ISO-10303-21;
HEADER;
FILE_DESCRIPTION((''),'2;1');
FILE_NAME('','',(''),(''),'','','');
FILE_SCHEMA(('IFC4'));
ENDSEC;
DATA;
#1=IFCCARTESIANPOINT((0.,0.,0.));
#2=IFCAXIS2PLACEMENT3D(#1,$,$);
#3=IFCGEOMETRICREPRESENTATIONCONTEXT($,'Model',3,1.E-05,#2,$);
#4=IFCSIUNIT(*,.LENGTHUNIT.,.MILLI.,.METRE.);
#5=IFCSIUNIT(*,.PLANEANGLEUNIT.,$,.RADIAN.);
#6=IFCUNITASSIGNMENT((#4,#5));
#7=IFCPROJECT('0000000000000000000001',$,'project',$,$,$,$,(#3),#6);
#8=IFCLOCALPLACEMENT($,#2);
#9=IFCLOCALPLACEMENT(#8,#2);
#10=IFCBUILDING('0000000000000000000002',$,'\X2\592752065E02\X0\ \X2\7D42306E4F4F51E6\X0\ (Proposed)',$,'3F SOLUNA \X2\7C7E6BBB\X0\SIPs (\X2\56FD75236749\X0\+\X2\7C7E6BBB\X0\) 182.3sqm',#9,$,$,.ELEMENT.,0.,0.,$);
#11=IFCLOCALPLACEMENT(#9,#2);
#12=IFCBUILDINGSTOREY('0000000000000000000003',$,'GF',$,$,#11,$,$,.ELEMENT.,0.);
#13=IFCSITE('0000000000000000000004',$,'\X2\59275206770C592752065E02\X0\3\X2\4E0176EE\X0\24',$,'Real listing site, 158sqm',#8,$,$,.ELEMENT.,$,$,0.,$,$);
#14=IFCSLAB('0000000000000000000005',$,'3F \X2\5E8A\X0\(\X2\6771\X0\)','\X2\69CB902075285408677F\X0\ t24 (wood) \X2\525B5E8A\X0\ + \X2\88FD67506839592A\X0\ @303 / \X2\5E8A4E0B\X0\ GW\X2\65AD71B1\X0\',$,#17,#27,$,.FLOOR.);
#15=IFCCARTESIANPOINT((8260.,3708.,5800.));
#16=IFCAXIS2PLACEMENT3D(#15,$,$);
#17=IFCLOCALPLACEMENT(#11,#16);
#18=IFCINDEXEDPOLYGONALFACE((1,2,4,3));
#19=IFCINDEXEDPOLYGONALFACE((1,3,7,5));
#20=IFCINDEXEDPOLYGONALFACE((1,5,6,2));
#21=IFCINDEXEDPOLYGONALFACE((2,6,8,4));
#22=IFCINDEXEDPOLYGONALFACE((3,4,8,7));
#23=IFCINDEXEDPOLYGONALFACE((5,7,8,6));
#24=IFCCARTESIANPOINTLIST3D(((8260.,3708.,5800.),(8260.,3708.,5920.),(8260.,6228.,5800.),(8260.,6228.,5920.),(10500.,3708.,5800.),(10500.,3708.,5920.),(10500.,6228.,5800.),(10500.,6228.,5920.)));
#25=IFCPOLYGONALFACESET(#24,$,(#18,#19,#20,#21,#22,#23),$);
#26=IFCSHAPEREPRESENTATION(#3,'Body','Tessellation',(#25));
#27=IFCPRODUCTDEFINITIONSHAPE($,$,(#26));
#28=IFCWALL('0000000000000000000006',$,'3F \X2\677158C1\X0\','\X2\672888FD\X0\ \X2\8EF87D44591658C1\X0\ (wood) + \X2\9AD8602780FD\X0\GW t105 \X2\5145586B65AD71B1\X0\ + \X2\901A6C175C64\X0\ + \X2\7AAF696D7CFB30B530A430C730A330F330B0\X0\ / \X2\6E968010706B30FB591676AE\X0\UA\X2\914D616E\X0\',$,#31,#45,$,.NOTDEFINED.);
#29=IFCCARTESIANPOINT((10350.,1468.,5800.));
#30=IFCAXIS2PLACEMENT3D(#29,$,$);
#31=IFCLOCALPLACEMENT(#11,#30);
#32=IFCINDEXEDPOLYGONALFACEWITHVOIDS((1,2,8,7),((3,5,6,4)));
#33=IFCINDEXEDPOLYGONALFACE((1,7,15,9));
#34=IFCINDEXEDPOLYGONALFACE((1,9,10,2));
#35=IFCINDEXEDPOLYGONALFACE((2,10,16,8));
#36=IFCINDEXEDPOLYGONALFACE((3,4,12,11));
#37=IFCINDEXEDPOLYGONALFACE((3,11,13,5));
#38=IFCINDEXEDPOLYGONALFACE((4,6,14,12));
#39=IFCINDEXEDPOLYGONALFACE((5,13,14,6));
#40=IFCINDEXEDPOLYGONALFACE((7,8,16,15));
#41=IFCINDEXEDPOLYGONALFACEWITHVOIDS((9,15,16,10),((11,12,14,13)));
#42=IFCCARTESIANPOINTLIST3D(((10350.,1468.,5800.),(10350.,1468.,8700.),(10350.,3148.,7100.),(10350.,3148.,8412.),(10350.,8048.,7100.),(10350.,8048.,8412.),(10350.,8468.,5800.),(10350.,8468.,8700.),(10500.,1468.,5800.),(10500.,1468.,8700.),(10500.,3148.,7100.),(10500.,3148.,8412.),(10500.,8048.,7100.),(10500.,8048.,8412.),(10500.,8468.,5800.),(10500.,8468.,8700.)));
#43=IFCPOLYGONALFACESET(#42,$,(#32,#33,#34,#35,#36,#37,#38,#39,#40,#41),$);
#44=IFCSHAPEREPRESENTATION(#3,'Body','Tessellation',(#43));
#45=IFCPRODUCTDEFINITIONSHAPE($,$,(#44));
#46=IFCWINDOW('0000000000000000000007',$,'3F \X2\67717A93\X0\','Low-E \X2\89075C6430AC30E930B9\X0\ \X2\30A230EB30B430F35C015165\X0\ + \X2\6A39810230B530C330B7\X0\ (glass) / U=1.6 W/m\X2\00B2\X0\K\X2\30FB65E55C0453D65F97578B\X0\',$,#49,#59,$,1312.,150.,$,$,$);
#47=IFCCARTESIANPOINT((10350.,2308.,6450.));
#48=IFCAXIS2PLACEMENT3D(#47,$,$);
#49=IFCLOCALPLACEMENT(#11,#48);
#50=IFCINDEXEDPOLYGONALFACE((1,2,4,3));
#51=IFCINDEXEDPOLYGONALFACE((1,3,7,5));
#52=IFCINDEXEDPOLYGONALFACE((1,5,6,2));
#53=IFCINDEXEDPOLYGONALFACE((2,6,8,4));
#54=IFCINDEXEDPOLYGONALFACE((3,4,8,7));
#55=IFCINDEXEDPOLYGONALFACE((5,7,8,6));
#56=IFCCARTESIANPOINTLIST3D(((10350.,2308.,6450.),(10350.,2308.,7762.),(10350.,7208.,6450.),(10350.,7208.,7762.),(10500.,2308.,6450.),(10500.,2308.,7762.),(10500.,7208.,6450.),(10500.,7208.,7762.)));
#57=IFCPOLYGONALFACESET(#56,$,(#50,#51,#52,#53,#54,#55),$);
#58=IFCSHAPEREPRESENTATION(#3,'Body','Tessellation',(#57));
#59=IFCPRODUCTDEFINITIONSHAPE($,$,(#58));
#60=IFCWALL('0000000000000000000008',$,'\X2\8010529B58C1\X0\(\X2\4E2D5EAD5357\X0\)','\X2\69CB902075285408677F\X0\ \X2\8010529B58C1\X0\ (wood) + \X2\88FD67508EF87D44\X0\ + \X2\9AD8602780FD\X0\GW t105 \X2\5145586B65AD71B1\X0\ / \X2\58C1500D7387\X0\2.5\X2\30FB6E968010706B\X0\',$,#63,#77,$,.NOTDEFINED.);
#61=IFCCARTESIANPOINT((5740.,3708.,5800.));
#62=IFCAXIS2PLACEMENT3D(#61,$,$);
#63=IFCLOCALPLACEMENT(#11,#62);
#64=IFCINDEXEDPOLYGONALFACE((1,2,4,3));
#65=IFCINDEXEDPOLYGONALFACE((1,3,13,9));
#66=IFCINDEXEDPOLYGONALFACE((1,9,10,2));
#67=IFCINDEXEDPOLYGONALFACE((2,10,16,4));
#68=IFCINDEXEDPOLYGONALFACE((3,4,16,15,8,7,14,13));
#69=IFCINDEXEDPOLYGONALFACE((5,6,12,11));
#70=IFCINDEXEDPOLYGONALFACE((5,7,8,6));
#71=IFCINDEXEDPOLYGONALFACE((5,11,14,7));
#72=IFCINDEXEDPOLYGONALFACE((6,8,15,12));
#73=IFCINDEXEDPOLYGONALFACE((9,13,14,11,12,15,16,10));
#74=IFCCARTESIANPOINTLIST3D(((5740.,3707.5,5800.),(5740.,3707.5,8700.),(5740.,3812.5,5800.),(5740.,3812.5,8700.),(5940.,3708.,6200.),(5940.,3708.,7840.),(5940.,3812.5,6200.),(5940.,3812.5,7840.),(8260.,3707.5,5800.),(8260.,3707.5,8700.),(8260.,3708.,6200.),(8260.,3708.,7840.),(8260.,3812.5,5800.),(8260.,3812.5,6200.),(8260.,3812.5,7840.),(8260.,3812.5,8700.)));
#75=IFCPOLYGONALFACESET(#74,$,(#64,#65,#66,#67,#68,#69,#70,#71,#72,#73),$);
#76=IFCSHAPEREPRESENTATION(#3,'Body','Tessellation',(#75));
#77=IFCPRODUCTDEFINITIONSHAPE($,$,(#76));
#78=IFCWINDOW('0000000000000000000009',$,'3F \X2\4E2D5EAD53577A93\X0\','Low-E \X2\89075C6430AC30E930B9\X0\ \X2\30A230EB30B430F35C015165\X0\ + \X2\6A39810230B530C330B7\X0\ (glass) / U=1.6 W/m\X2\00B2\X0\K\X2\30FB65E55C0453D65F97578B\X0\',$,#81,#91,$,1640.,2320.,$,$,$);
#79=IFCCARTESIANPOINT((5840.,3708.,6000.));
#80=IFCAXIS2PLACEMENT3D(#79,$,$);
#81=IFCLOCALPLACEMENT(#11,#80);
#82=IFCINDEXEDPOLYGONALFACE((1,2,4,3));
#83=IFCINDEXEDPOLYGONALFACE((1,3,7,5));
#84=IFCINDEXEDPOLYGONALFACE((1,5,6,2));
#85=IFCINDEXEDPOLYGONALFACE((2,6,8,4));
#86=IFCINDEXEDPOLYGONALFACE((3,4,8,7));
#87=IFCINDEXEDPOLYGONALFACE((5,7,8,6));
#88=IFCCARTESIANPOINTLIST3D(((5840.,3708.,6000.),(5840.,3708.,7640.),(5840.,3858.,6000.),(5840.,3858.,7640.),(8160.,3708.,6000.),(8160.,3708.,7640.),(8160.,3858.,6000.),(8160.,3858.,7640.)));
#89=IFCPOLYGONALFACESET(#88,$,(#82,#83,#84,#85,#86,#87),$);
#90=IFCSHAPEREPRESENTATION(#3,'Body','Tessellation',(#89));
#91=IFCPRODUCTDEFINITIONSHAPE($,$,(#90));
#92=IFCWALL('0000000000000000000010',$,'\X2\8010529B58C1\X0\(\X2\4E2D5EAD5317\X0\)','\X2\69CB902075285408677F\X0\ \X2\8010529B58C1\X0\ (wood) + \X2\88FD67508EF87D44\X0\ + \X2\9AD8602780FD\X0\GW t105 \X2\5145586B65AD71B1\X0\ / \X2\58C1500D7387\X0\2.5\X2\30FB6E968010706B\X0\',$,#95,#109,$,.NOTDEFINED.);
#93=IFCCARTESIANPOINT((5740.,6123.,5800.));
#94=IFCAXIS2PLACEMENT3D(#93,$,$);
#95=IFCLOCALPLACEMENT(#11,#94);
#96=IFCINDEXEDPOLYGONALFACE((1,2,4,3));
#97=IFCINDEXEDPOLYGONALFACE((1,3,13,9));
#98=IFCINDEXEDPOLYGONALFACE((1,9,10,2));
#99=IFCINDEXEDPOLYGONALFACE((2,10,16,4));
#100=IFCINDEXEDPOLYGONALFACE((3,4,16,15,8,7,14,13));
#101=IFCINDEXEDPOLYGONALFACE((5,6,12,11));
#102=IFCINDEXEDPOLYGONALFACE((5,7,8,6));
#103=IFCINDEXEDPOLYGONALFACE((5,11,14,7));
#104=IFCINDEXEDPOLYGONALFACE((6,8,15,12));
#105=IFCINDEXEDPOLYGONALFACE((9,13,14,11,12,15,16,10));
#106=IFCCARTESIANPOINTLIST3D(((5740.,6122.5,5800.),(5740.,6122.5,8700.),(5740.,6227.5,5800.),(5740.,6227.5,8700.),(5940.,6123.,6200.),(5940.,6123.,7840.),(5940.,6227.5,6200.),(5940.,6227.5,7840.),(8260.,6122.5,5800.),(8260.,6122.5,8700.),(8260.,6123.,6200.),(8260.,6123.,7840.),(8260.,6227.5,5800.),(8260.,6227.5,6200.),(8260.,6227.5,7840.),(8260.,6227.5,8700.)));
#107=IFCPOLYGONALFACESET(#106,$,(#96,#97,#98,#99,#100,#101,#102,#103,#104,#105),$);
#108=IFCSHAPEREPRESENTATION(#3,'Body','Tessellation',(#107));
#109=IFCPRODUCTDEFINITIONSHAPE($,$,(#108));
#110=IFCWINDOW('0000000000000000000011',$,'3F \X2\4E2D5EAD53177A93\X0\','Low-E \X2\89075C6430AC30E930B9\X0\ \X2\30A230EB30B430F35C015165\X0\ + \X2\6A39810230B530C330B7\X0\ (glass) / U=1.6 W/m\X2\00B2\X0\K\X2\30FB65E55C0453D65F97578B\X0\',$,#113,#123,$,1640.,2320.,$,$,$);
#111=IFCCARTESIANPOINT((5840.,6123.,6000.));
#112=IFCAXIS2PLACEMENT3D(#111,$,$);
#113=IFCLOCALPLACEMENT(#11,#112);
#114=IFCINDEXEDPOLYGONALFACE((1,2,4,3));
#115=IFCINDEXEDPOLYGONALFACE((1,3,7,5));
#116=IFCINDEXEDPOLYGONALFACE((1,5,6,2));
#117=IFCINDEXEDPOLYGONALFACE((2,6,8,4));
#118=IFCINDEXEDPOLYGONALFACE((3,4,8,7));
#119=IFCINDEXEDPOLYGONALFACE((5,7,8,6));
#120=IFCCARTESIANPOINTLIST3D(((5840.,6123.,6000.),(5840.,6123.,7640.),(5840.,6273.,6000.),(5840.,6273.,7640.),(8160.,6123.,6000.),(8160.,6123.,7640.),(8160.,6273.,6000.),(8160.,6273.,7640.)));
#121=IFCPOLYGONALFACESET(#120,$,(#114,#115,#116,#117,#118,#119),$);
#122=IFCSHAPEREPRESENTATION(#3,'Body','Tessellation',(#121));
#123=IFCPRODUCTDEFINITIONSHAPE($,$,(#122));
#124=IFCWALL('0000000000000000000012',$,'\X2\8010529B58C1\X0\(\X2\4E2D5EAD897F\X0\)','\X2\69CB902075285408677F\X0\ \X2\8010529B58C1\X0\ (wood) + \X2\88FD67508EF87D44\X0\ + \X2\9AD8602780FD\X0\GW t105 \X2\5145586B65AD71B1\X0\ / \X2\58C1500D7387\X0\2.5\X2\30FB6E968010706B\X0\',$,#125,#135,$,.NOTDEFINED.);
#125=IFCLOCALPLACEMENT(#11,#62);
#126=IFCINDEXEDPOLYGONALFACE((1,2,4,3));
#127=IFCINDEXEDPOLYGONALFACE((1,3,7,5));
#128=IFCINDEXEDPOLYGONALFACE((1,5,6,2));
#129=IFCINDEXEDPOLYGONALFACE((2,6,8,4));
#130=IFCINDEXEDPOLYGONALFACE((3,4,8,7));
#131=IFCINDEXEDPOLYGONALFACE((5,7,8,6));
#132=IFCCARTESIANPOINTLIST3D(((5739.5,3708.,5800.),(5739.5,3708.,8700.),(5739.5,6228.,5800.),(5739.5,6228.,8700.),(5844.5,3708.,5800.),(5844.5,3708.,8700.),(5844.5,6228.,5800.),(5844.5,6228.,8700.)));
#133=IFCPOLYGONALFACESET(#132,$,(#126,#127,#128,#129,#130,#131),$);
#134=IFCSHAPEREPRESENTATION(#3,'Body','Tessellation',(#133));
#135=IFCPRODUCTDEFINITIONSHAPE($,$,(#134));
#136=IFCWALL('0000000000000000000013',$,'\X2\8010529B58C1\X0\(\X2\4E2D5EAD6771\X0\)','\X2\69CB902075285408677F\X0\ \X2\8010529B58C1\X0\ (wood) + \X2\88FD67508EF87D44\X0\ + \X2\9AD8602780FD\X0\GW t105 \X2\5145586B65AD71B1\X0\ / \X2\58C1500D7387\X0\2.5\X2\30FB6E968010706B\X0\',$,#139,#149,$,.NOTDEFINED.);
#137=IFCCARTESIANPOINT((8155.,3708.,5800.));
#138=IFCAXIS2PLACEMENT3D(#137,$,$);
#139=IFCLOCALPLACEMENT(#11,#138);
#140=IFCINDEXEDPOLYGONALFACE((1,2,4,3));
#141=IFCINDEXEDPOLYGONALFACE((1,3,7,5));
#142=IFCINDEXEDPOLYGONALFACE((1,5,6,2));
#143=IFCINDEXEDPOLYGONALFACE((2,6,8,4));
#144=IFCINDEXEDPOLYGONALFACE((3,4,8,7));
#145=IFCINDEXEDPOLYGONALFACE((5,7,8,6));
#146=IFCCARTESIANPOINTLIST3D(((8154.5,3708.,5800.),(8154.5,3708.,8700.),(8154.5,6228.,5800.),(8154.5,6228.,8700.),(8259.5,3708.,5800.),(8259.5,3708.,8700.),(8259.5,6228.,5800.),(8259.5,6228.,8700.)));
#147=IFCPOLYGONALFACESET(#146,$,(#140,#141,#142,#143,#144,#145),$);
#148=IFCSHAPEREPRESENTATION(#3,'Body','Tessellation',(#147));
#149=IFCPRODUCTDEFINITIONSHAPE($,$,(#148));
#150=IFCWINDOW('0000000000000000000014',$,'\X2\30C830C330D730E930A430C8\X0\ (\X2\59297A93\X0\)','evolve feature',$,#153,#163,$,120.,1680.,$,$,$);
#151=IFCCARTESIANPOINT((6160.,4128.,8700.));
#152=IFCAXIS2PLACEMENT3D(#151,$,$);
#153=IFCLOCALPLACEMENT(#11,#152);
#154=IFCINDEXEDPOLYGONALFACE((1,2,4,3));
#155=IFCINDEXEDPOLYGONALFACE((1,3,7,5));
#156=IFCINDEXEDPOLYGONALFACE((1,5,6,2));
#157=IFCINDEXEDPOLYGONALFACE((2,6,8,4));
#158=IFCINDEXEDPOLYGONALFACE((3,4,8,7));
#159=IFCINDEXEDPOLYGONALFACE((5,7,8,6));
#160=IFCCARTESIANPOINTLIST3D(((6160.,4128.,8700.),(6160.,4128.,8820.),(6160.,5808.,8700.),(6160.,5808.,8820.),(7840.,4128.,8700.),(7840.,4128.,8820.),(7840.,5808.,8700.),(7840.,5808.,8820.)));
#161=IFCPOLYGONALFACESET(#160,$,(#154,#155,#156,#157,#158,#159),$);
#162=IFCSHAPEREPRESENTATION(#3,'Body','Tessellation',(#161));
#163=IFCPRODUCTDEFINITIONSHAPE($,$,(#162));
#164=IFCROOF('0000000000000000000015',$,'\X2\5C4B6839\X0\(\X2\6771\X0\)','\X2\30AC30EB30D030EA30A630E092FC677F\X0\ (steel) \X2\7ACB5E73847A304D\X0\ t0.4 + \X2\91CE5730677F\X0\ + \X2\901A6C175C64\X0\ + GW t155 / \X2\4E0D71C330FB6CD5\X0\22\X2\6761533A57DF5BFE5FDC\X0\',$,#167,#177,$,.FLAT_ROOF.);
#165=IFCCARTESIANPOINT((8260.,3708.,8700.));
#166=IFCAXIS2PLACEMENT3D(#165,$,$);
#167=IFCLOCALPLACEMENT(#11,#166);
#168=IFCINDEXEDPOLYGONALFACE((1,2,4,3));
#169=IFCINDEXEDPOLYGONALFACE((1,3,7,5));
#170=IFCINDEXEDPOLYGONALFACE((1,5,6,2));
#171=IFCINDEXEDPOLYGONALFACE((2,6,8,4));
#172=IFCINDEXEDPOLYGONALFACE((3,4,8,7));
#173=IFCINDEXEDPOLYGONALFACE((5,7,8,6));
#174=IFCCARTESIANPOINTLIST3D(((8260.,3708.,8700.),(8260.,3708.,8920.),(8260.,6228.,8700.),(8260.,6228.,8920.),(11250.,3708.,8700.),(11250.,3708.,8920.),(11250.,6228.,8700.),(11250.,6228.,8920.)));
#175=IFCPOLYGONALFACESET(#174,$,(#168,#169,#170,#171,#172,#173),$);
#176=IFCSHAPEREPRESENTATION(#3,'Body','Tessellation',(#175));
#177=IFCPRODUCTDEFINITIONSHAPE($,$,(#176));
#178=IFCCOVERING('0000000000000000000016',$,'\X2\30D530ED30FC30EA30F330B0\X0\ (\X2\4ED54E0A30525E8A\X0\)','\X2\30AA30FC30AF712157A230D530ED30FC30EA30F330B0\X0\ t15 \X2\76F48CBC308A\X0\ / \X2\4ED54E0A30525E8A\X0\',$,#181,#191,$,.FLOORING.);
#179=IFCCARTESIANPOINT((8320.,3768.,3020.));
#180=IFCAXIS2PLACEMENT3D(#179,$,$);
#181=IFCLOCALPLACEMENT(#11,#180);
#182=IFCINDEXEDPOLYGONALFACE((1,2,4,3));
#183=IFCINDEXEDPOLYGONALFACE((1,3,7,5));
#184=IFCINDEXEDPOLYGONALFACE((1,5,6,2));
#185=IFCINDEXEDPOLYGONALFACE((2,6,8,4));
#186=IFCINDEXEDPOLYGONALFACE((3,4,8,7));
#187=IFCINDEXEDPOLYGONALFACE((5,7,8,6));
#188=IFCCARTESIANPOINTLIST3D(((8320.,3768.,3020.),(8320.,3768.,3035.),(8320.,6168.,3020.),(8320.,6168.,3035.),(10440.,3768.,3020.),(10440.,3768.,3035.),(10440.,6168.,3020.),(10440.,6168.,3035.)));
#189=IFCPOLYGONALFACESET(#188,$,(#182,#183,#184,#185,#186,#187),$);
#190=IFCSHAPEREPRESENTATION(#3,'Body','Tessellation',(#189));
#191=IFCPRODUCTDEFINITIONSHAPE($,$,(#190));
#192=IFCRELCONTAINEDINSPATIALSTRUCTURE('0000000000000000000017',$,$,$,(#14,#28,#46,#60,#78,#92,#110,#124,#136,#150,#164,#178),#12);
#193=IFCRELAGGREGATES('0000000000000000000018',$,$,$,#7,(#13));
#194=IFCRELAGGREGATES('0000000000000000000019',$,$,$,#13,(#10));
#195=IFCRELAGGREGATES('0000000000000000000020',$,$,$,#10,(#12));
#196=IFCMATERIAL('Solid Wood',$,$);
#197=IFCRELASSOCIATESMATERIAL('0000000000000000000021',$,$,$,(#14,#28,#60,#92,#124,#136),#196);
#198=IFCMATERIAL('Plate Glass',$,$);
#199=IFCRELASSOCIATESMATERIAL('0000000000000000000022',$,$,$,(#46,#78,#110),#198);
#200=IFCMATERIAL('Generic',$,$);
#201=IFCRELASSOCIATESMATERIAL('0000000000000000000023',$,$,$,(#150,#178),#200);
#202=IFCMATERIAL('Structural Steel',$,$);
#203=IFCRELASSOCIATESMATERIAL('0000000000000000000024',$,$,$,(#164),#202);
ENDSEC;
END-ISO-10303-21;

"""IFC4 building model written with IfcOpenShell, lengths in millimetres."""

from ifc_helpers import new_model, si_unit, frame, frame_2d, origin, place, context, project, spatial, rectangle, extrude, material, element, fill, save


model = new_model("IFC4")

# Units and contexts
model_context = context("Model", 3, precision=1e-05, world=origin())
ifc_project = project(units=[si_unit("LENGTHUNIT", "METRE", prefix="MILLI"), si_unit("PLANEANGLEUNIT", "RADIAN")], contexts=[model_context])

# Site, building, storey
site_placement = place(None, origin())
site = spatial("IfcSite", under=ifc_project, at=site_placement, Name="大分県大分市3丁目24", ObjectType="Real listing site, 158sqm", CompositionType="ELEMENT", RefElevation=0.0)
building_placement = place(site_placement, origin())
building = spatial("IfcBuilding", under=site, at=building_placement, Name="大分市 終の住処 (Proposed)", ObjectType="3F SOLUNA 籾殻SIPs (国産杉+籾殻) 182.3sqm", CompositionType="ELEMENT", ElevationOfRefHeight=0.0, ElevationOfTerrain=0.0)
storey_placement = place(building_placement, origin())
storey = spatial("IfcBuildingStorey", under=building, at=storey_placement, Name="GF", CompositionType="ELEMENT", Elevation=0.0)

# Slab
ifc_material_1 = material(Name="Solid Wood")
slab_placement = place(storey_placement, frame((8260.0, 3708.0, 5800.0)))
element("IfcSlab", 1, at=slab_placement, inside=storey, material=ifc_material_1, Name="3F 床(東)", Description="構造用合板 t24 (wood) 剛床 + 製材根太 @303 / 床下 GW断熱", PredefinedType="FLOOR", context=model_context, shape_type="SweptSolid", body=[
    extrude(rectangle(XDim=2240.0, YDim=2520.0, at=frame_2d((1120.0, 1260.0))), frame((8260.0, 3708.0, 5800.0)), (0.0, 0.0, 1.0), 120.0),
])

# Walls, openings, windows
wall_1_placement = place(storey_placement, frame((10350.0, 1468.0, 5800.0)))
wall_1 = element("IfcWall", 2, at=wall_1_placement, inside=storey, material=ifc_material_1, Name="3F 東壁", Description="木製 軸組外壁 (wood) + 高性能GW t105 充填断熱 + 通気層 + 窯業系サイディング / 準耐火・外皮UA配慮", PredefinedType="NOTDEFINED", context=model_context, shape_type="SweptSolid", body=[
    extrude(rectangle(XDim=150.0, YDim=7000.0, at=frame_2d((75.0, 3500.0))), frame((10350.0, 1468.0, 5800.0)), (0.0, 0.0, 1.0), 2900.0),
])
opening_1_placement = place(storey_placement, frame((10350.0, 2308.0, 6450.0)))
opening_1 = element("IfcOpeningElement", 3, at=opening_1_placement, cuts=wall_1, PredefinedType="NOTDEFINED", context=model_context, shape_type="SweptSolid", body=[
    extrude(rectangle(XDim=150.0, YDim=4900.0, at=frame_2d((75.0, 2450.0))), frame((10350.0, 2308.0, 6450.0)), (0.0, 0.0, 1.0), 1312.0),
])
ifc_material_2 = material(Name="Plate Glass")
window_1_placement = place(storey_placement, frame((10350.0, 2308.0, 6450.0)))
window_1 = element("IfcWindow", 4, at=window_1_placement, inside=storey, material=ifc_material_2, Name="3F 東窓", Description="Low-E 複層ガラス アルゴン封入 + 樹脂サッシ (glass) / U=1.6 W/m²K・日射取得型", OverallHeight=1312.0, OverallWidth=150.0, context=model_context, shape_type="SweptSolid", body=[
    extrude(rectangle(XDim=150.0, YDim=4900.0, at=frame_2d((75.0, 2450.0))), frame((10350.0, 2308.0, 6450.0)), (0.0, 0.0, 1.0), 1312.0),
])
fill(opening_1, window_1)
wall_2_placement = place(storey_placement, frame((5740.0, 3708.0, 5800.0)))
wall_2 = element("IfcWall", 5, at=wall_2_placement, inside=storey, material=ifc_material_1, Name="耐力壁(中庭南)", Description="構造用合板 耐力壁 (wood) + 製材軸組 + 高性能GW t105 充填断熱 / 壁倍率2.5・準耐火", PredefinedType="NOTDEFINED", context=model_context, shape_type="SweptSolid", body=[
    extrude(rectangle(XDim=2520.0, YDim=105.0, at=frame_2d((1260.0, 52.0))), frame((5740.0, 3708.0, 5800.0)), (0.0, 0.0, 1.0), 2900.0),
])
opening_2_placement = place(storey_placement, frame((5840.0, 3708.0, 6000.0)))
opening_2 = element("IfcOpeningElement", 6, at=opening_2_placement, cuts=wall_2, PredefinedType="NOTDEFINED", context=model_context, shape_type="SweptSolid", body=[
    extrude(rectangle(XDim=2320.0, YDim=150.0, at=frame_2d((1160.0, 75.0))), frame((5840.0, 3708.0, 6000.0)), (0.0, 0.0, 1.0), 1640.0),
])
window_2_placement = place(storey_placement, frame((5840.0, 3708.0, 6000.0)))
window_2 = element("IfcWindow", 7, at=window_2_placement, inside=storey, material=ifc_material_2, Name="3F 中庭南窓", Description="Low-E 複層ガラス アルゴン封入 + 樹脂サッシ (glass) / U=1.6 W/m²K・日射取得型", OverallHeight=1640.0, OverallWidth=2320.0, context=model_context, shape_type="SweptSolid", body=[
    extrude(rectangle(XDim=2320.0, YDim=150.0, at=frame_2d((1160.0, 75.0))), frame((5840.0, 3708.0, 6000.0)), (0.0, 0.0, 1.0), 1640.0),
])
fill(opening_2, window_2)
wall_3_placement = place(storey_placement, frame((5740.0, 6123.0, 5800.0)))
wall_3 = element("IfcWall", 8, at=wall_3_placement, inside=storey, material=ifc_material_1, Name="耐力壁(中庭北)", Description="構造用合板 耐力壁 (wood) + 製材軸組 + 高性能GW t105 充填断熱 / 壁倍率2.5・準耐火", PredefinedType="NOTDEFINED", context=model_context, shape_type="SweptSolid", body=[
    extrude(rectangle(XDim=2520.0, YDim=105.0, at=frame_2d((1260.0, 52.0))), frame((5740.0, 6123.0, 5800.0)), (0.0, 0.0, 1.0), 2900.0),
])
opening_3_placement = place(storey_placement, frame((5840.0, 6123.0, 6000.0)))
opening_3 = element("IfcOpeningElement", 9, at=opening_3_placement, cuts=wall_3, PredefinedType="NOTDEFINED", context=model_context, shape_type="SweptSolid", body=[
    extrude(rectangle(XDim=2320.0, YDim=150.0, at=frame_2d((1160.0, 75.0))), frame((5840.0, 6123.0, 6000.0)), (0.0, 0.0, 1.0), 1640.0),
])
window_3_placement = place(storey_placement, frame((5840.0, 6123.0, 6000.0)))
window_3 = element("IfcWindow", 10, at=window_3_placement, inside=storey, material=ifc_material_2, Name="3F 中庭北窓", Description="Low-E 複層ガラス アルゴン封入 + 樹脂サッシ (glass) / U=1.6 W/m²K・日射取得型", OverallHeight=1640.0, OverallWidth=2320.0, context=model_context, shape_type="SweptSolid", body=[
    extrude(rectangle(XDim=2320.0, YDim=150.0, at=frame_2d((1160.0, 75.0))), frame((5840.0, 6123.0, 6000.0)), (0.0, 0.0, 1.0), 1640.0),
])
fill(opening_3, window_3)

# Walls
wall_4_placement = place(storey_placement, frame((5740.0, 3708.0, 5800.0)))
element("IfcWall", 11, at=wall_4_placement, inside=storey, material=ifc_material_1, Name="耐力壁(中庭西)", Description="構造用合板 耐力壁 (wood) + 製材軸組 + 高性能GW t105 充填断熱 / 壁倍率2.5・準耐火", PredefinedType="NOTDEFINED", context=model_context, shape_type="SweptSolid", body=[
    extrude(rectangle(XDim=105.0, YDim=2520.0, at=frame_2d((52.0, 1260.0))), frame((5740.0, 3708.0, 5800.0)), (0.0, 0.0, 1.0), 2900.0),
])
wall_5_placement = place(storey_placement, frame((8155.0, 3708.0, 5800.0)))
element("IfcWall", 12, at=wall_5_placement, inside=storey, material=ifc_material_1, Name="耐力壁(中庭東)", Description="構造用合板 耐力壁 (wood) + 製材軸組 + 高性能GW t105 充填断熱 / 壁倍率2.5・準耐火", PredefinedType="NOTDEFINED", context=model_context, shape_type="SweptSolid", body=[
    extrude(rectangle(XDim=105.0, YDim=2520.0, at=frame_2d((52.0, 1260.0))), frame((8155.0, 3708.0, 5800.0)), (0.0, 0.0, 1.0), 2900.0),
])

# Window
ifc_material_3 = material(Name="Generic")
window_4_placement = place(storey_placement, frame((6160.0, 4128.0, 8700.0)))
element("IfcWindow", 13, at=window_4_placement, inside=storey, material=ifc_material_3, Name="トップライト (天窓)", Description="evolve feature", OverallHeight=120.0, OverallWidth=1680.0, context=model_context, shape_type="SweptSolid", body=[
    extrude(rectangle(XDim=1680.0, YDim=1680.0, at=frame_2d((840.0, 840.0))), frame((6160.0, 4128.0, 8700.0)), (0.0, 0.0, 1.0), 120.0),
])

# Roof
ifc_material_4 = material(Name="Structural Steel")
for number, where, name in (
    (14, (8260.0, 3708.0, 8700.0), "屋根(東)"),
):
    element("IfcRoof", number, at=place(storey_placement, frame(where)), inside=storey, material=ifc_material_4, Name=name, Description="ガルバリウム鋼板 (steel) 立平葺き t0.4 + 野地板 + 通気層 + GW t155 / 不燃・法22条区域対応", PredefinedType="FLAT_ROOF", context=model_context, shape_type="SweptSolid", body=[
        extrude(rectangle(XDim=2990.0, YDim=2520.0, at=frame_2d((1495.0, 1260.0))), frame((8260.0, 3708.0, 8700.0)), (0.0, 0.0, 1.0), 220.0),
    ])

# Covering
covering_1_placement = place(storey_placement, frame((8320.0, 3768.0, 3020.0)))
element("IfcCovering", 15, at=covering_1_placement, inside=storey, material=ifc_material_3, Name="フローリング (仕上げ床)", Description="オーク無垢フローリング t15 直貼り / 仕上げ床", PredefinedType="FLOORING", context=model_context, shape_type="SweptSolid", body=[
    extrude(rectangle(XDim=2120.0, YDim=2400.0, at=frame_2d((1060.0, 1200.0))), frame((8320.0, 3768.0, 3020.0)), (0.0, 0.0, 1.0), 15.0),
])

save(model, "model.ifc")
